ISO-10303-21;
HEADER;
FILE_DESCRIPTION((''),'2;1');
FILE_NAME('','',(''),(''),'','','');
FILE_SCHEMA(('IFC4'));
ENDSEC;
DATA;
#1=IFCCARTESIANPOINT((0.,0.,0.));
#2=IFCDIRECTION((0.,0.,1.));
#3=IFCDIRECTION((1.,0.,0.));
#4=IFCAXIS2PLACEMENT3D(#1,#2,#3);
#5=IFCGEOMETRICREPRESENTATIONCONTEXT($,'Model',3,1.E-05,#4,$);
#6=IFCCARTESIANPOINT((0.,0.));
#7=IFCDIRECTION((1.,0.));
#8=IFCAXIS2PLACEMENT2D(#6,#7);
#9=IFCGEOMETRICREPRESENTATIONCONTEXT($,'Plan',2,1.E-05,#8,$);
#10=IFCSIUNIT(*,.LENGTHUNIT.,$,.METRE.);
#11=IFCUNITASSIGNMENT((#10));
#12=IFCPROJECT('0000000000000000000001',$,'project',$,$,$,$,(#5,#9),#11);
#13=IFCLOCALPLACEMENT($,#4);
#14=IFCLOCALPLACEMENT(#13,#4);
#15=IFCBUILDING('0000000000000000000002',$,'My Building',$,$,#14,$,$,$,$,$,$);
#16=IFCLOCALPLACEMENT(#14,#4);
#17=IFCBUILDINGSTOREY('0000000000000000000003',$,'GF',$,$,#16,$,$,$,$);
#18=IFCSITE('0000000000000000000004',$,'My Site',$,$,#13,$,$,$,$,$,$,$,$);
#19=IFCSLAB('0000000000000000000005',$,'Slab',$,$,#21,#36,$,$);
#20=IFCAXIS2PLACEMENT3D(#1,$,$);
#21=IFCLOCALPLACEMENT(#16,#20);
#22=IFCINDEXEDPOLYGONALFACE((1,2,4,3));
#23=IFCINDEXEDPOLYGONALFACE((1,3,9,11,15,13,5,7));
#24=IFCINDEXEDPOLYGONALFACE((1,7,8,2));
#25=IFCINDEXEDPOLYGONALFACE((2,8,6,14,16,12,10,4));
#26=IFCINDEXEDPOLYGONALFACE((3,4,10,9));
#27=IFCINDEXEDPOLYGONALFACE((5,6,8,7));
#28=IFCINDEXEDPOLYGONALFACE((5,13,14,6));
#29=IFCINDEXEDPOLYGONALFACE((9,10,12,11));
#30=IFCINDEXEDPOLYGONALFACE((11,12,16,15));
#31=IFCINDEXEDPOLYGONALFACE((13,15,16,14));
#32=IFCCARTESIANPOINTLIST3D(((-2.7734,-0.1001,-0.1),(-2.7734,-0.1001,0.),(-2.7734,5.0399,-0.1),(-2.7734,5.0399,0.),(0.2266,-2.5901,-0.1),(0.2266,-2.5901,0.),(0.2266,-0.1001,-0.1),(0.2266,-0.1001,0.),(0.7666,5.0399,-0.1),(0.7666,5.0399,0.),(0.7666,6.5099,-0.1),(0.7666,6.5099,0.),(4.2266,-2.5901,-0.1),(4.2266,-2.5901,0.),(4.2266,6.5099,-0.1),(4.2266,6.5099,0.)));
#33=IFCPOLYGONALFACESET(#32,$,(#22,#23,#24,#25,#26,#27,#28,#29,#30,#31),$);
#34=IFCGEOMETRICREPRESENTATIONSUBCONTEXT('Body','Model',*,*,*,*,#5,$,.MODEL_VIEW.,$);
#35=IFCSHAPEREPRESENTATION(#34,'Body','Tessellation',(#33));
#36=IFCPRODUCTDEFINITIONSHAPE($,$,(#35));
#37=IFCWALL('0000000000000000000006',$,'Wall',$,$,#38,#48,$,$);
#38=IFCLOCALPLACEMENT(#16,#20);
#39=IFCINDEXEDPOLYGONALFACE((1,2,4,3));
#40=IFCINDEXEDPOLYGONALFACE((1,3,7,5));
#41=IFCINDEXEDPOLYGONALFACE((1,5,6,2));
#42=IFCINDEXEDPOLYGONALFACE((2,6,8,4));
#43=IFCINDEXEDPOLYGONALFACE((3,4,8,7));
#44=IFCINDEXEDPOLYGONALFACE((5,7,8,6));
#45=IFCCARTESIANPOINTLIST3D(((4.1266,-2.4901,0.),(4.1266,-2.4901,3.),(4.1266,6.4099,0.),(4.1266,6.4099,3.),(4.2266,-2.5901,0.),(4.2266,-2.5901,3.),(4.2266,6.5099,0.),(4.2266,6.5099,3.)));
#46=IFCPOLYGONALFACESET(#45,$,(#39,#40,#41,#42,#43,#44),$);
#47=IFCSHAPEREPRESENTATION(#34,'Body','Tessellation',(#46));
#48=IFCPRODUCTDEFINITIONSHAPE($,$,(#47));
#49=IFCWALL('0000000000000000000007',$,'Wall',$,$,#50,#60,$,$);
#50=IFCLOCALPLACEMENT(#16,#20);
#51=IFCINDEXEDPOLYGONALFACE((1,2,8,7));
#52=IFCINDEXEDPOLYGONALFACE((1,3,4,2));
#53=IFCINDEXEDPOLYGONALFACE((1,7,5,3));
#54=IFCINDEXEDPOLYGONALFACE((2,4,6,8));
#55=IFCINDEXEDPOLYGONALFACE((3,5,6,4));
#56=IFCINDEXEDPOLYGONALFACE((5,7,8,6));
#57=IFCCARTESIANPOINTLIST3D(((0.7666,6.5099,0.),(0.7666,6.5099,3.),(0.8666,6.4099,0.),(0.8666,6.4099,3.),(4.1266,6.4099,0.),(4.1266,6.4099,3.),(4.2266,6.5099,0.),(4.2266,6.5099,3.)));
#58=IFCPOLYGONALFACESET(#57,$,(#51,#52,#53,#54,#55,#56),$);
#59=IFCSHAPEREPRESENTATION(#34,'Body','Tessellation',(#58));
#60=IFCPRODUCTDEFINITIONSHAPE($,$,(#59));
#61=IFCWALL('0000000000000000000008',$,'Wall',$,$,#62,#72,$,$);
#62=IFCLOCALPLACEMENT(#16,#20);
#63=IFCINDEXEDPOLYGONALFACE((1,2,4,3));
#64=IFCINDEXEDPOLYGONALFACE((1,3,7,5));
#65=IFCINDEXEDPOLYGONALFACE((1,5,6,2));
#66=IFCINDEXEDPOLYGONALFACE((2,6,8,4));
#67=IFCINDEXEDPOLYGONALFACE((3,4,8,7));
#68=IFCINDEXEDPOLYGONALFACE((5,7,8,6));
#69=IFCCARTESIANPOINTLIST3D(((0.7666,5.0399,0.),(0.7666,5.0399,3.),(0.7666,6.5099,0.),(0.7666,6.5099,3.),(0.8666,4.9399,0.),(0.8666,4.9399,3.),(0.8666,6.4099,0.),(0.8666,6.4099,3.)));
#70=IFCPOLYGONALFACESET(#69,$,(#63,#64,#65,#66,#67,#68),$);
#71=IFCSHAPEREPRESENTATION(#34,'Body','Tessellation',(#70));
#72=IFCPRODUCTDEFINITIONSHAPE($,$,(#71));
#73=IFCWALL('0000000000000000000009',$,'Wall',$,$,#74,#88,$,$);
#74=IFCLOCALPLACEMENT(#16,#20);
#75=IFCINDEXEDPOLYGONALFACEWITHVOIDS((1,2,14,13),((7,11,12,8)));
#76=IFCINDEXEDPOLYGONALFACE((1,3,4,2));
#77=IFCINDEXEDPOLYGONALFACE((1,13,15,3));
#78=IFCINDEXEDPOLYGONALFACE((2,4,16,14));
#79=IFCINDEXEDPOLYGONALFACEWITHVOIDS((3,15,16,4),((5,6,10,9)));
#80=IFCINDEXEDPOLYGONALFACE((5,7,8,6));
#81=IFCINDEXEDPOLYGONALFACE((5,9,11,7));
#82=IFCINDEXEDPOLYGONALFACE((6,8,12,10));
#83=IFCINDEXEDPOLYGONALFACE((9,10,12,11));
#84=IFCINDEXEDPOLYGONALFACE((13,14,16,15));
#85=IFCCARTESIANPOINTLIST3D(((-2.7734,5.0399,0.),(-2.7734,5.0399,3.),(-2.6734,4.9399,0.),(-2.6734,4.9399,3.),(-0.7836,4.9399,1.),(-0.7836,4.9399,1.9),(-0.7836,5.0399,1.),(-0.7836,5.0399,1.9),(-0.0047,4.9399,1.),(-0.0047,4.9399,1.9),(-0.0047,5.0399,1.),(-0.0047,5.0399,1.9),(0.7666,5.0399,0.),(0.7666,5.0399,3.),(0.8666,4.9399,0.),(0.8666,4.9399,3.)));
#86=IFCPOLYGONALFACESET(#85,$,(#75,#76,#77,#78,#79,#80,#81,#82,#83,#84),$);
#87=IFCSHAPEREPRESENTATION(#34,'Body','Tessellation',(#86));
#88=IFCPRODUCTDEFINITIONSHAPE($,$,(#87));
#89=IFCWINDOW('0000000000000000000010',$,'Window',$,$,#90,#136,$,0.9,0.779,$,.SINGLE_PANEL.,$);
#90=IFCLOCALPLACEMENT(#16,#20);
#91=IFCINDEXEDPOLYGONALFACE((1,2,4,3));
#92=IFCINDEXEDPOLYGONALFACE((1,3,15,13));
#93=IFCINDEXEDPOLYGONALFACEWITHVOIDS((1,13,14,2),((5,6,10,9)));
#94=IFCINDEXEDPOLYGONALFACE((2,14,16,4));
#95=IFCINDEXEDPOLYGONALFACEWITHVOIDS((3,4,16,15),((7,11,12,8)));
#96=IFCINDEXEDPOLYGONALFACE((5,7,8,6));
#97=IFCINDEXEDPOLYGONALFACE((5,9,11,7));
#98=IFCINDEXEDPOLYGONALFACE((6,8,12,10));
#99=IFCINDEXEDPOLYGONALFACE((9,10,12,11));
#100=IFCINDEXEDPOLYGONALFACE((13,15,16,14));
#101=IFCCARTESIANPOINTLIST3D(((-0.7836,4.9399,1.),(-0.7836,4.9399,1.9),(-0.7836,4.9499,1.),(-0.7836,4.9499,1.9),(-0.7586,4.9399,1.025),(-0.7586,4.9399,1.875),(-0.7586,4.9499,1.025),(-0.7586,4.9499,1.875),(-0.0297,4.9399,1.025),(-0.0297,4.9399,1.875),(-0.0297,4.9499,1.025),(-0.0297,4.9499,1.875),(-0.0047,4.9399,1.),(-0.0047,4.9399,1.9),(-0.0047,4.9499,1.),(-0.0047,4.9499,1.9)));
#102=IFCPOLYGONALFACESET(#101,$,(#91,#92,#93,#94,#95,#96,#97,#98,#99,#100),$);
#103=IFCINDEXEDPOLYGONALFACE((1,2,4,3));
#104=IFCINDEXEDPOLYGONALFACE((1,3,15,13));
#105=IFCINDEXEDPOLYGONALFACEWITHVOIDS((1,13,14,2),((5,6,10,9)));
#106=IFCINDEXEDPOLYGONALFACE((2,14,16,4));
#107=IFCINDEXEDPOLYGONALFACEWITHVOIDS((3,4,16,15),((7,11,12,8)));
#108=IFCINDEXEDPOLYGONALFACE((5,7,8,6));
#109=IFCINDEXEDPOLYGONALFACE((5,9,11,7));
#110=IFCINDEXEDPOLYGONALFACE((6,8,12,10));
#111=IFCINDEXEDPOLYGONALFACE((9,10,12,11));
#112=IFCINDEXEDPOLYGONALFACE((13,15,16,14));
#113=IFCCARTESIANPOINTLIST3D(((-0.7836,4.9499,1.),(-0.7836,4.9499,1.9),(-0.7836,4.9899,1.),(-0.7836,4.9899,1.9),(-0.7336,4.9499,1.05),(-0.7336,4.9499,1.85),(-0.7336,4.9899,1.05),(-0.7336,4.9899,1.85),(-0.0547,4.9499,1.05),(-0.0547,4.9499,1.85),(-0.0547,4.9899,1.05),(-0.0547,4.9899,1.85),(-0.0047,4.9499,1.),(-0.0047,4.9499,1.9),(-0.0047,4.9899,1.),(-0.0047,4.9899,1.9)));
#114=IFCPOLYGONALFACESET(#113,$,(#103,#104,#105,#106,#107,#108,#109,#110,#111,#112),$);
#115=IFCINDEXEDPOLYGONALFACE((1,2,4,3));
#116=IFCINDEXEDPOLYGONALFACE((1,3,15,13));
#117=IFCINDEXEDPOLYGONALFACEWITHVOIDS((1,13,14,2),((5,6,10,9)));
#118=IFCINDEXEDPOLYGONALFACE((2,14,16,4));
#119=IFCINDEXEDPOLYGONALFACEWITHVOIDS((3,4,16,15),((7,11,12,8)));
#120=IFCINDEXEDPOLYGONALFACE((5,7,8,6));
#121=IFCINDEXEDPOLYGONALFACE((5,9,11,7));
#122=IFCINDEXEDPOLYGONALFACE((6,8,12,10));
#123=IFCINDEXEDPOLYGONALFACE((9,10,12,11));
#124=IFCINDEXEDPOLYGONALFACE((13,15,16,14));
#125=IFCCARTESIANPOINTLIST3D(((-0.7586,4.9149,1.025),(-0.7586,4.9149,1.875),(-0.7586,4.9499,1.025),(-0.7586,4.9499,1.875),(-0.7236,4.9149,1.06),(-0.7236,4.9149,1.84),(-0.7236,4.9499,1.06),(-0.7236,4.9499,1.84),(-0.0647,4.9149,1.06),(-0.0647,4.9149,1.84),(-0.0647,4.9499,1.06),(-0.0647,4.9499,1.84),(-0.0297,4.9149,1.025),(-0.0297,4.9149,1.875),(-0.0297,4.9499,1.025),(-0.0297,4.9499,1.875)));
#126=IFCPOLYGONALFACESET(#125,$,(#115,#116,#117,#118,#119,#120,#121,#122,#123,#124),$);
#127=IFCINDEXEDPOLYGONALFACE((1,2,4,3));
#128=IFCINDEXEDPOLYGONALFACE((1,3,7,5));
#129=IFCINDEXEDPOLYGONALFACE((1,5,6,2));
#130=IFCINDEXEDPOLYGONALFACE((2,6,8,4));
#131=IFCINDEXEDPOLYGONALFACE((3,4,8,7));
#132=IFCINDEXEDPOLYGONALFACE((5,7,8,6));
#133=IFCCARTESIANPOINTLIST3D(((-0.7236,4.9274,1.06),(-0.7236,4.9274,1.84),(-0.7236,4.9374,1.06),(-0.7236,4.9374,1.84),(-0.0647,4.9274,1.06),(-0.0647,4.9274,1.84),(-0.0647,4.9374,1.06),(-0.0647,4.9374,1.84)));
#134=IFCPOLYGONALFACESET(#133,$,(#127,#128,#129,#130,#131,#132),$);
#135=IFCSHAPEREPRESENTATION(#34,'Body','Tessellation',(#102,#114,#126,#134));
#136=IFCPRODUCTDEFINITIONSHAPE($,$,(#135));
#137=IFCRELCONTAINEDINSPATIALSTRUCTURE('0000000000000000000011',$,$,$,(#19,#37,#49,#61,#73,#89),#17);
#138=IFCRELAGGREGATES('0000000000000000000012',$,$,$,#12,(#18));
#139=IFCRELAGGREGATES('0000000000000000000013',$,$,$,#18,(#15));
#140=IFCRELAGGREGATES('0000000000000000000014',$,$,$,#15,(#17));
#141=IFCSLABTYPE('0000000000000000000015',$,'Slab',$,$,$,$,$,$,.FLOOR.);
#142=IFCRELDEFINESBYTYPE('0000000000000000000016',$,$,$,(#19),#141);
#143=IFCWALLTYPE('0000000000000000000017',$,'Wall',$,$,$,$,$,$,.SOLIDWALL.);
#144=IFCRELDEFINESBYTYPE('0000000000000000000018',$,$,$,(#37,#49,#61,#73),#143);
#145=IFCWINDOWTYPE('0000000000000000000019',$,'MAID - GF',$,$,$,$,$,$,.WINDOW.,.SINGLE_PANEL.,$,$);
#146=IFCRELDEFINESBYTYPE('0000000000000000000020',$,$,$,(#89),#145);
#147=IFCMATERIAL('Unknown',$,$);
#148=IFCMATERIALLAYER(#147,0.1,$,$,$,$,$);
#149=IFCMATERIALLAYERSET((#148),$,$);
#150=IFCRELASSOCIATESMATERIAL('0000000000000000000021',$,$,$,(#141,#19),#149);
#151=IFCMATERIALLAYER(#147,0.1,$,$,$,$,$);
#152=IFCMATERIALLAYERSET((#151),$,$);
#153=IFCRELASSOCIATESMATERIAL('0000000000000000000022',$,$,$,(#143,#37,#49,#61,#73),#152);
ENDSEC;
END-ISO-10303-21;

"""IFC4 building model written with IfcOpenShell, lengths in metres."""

from ifc_helpers import new_model, entity, si_unit, frame, origin_with_axes, origin_2d_with_axis, place, context, subcontext, project, spatial, line, indexed_curve, outline, extrude, shape, source, transform, mapped, material, layer, layer_set, layer_usage, type_object, type_shapes, element, fill, save


model = new_model("IFC4")

# Units and contexts
model_context = context("Model", 3, precision=1e-05, world=origin_with_axes())
plan_context = context("Plan", 2, precision=1e-05, world=origin_2d_with_axis())
body_context_1 = subcontext(model_context, "Body", "Model", "MODEL_VIEW")
body_context_2 = subcontext(plan_context, "Body", "Plan", "PLAN_VIEW")
ifc_project = project(units=[si_unit("LENGTHUNIT", "METRE")], contexts=[model_context, plan_context])

# Site, building, storey
site_placement = place(None, origin_with_axes())
site = spatial("IfcSite", under=ifc_project, at=site_placement, Name="My Site")
building_placement = place(site_placement, origin_with_axes())
building = spatial("IfcBuilding", under=site, at=building_placement, Name="My Building")
storey_placement = place(building_placement, origin_with_axes())
storey = spatial("IfcBuildingStorey", under=building, at=storey_placement, Name="GF")

# Slab
ifc_material = material(Name="Unknown")
ifc_layer_1 = layer(ifc_material, 0.1)
ifc_layer_set_1 = layer_set([ifc_layer_1])
ifc_layer_usage_1 = layer_usage(ifc_layer_set_1, "AXIS3", "POSITIVE", -0.1)
slab_type = type_object("IfcSlabType", Name="Slab", PredefinedType="FLOOR", material=ifc_layer_set_1)
slab_placement = place(storey_placement, frame((4.2266, -2.5901, 0.0), z_axis=(0.0, 0.0, 1.0), x_axis=(1.0, 0.0, 0.0)))
element("IfcSlab", 1, at=slab_placement, inside=storey, type_object=slab_type, material=ifc_layer_usage_1, Name="Slab", context=body_context_1, shape_type="SweptSolid", body=[
    extrude(outline(indexed_curve([(0.0, 0.0), (0.0, 9.1), (-3.46, 9.1), (-3.46, 7.63), (-7.0, 7.63), (-7.0, 2.49), (-4.0, 2.49), (-4.0, 0.0), (0.0, 0.0)])), frame((0.0, 0.0, -0.1), z_axis=(0.0, 0.0, 1.0), x_axis=(1.0, 0.0, 0.0)), (0.0, 0.0, 1.0), 0.1),
])

# Shared definitions
ifc_layer_2 = layer(ifc_material, 0.1)
ifc_layer_set_2 = layer_set([ifc_layer_2])
wall_type = type_object("IfcWallType", Name="Wall", PredefinedType="SOLIDWALL", material=ifc_layer_set_2)

# Walls
ifc_layer_usage_2 = layer_usage(ifc_layer_set_2, "AXIS2", "POSITIVE", 0.0)
wall_1_placement = place(storey_placement, frame((4.2266, -2.5901, 0.0), z_axis=(0.0, 0.0, 1.0), x_axis=(0.0, 1.0, 0.0)))
element("IfcWall", 2, at=wall_1_placement, inside=storey, type_object=wall_type, material=ifc_layer_usage_2, Name="Wall", context=body_context_1, shape_type="SweptSolid", body=[
    extrude(outline(indexed_curve([(0.0, 0.0), (0.1, 0.1), (9.0, 0.1), (9.1, 0.0)], segments=[line(1, 2, 3, 4, 1)])), origin_with_axes(), (0.0, 0.0, 1.0), 3.0),
])
ifc_layer_usage_3 = layer_usage(ifc_layer_set_2, "AXIS2", "POSITIVE", 0.0)
wall_2_placement = place(storey_placement, frame((4.2266, 6.5099, 0.0), z_axis=(0.0, 0.0, 1.0), x_axis=(-1.0, 0.0, 0.0)))
element("IfcWall", 3, at=wall_2_placement, inside=storey, type_object=wall_type, material=ifc_layer_usage_3, Name="Wall", context=body_context_1, shape_type="SweptSolid", body=[
    extrude(outline(indexed_curve([(0.0, 0.0), (0.1, 0.1), (3.36, 0.1), (3.46, 0.0)], segments=[line(1, 2, 3, 4, 1)])), origin_with_axes(), (0.0, 0.0, 1.0), 3.0),
])
ifc_layer_usage_4 = layer_usage(ifc_layer_set_2, "AXIS2", "POSITIVE", 0.0)
wall_3_placement = place(storey_placement, frame((0.7666, 6.5099, 0.0), z_axis=(0.0, 0.0, 1.0), x_axis=(0.0, -1.0, 0.0)))
element("IfcWall", 4, at=wall_3_placement, inside=storey, type_object=wall_type, material=ifc_layer_usage_4, Name="Wall", context=body_context_1, shape_type="SweptSolid", body=[
    extrude(outline(indexed_curve([(0.0, 0.0), (0.1, 0.1), (1.57, 0.1), (1.47, 0.0)], segments=[line(1, 2, 3, 4, 1)])), origin_with_axes(), (0.0, 0.0, 1.0), 3.0),
])

# Wall, opening, window
ifc_layer_usage_5 = layer_usage(ifc_layer_set_2, "AXIS2", "POSITIVE", 0.0)
wall_4_placement = place(storey_placement, frame((0.7666, 5.0399, 0.0), z_axis=(0.0, 0.0, 1.0), x_axis=(-1.0, 0.0, 0.0)))
wall_4 = element("IfcWall", 5, at=wall_4_placement, inside=storey, type_object=wall_type, material=ifc_layer_usage_5, Name="Wall", context=body_context_1, shape_type="SweptSolid", body=[
    extrude(outline(indexed_curve([(0.0, 0.0), (-0.1, 0.1), (3.44, 0.1), (3.54, 0.0)], segments=[line(1, 2, 3, 4, 1)])), origin_with_axes(), (0.0, 0.0, 1.0), 3.0),
])
shared_shape_1 = source(origin_with_axes(), body_context_1, "Body", "SweptSolid", [
    extrude(outline(indexed_curve([(0.0, 0.0), (0.779, 0.0), (0.779, 0.9), (0.0, 0.9)], segments=[line(1, 2, 3, 4, 1)])), frame((0.0, -0.6, 0.0), z_axis=(0.0, -1.0, 0.0), x_axis=(1.0, 0.0, 0.0)), (0.0, 0.0, -1.0), 1.2),
])
opening_1_placement = place(wall_4_placement, frame((0.7713, 0.0, 1.0), z_axis=(0.0, 0.0, 1.0), x_axis=(1.0, 0.0, 0.0)))
opening_1 = element("IfcOpeningElement", 6, at=opening_1_placement, cuts=wall_4, PredefinedType="OPENING", context=body_context_1, shape_type="MappedRepresentation", body=[
    mapped(shared_shape_1, transform((0.0, 0.0, 0.0), x_axis=(1.0, 0.0, 0.0), y_axis=(0.0, 1.0, 0.0), z_axis=(0.0, 0.0, 1.0), scale=1.0)),
])
window_type_1 = type_object("IfcWindowType", Name="MAID - GF", PartitioningType="SINGLE_PANEL", PredefinedType="WINDOW")
shared_shape_2 = source(origin_with_axes(), body_context_1, "Body", "SweptSolid", [
    extrude(outline(indexed_curve([(0.0, 0.0), (0.779, 0.0), (0.779, 0.9), (0.0, 0.9)], segments=[line(1, 2, 3, 4, 1)]), holes=[indexed_curve([(0.025, 0.025), (0.754, 0.025), (0.754, 0.875), (0.025, 0.875)], segments=[line(1, 2, 3, 4, 1)])]), frame((0.0, 0.09, 0.0), z_axis=(0.0, -1.0, 0.0), x_axis=(1.0, 0.0, 0.0)), (0.0, 0.0, -1.0), 0.01),
    extrude(outline(indexed_curve([(0.0, 0.0), (0.779, 0.0), (0.779, 0.9), (0.0, 0.9)], segments=[line(1, 2, 3, 4, 1)]), holes=[indexed_curve([(0.05, 0.05), (0.729, 0.05), (0.729, 0.85), (0.05, 0.85)], segments=[line(1, 2, 3, 4, 1)])]), frame((0.0, 0.05, 0.0), z_axis=(0.0, -1.0, 0.0), x_axis=(1.0, 0.0, 0.0)), (0.0, 0.0, -1.0), 0.04),
    extrude(outline(indexed_curve([(0.0, 0.0), (0.729, 0.0), (0.729, 0.85), (0.0, 0.85)], segments=[line(1, 2, 3, 4, 1)]), holes=[indexed_curve([(0.035, 0.035), (0.694, 0.035), (0.694, 0.815), (0.035, 0.815)], segments=[line(1, 2, 3, 4, 1)])]), frame((0.025, 0.09, 0.025), z_axis=(0.0, -1.0, 0.0), x_axis=(1.0, 0.0, 0.0)), (0.0, 0.0, -1.0), 0.035),
    extrude(outline(indexed_curve([(0.035, 0.035), (0.694, 0.035), (0.694, 0.815), (0.035, 0.815)], segments=[line(1, 2, 3, 4, 1)])), frame((0.025, 0.1025, 0.025), z_axis=(0.0, -1.0, 0.0), x_axis=(1.0, 0.0, 0.0)), (0.0, 0.0, -1.0), 0.01),
])
shared_shape_3 = source(origin_with_axes(), body_context_2, "Body", "Curve2D", [
    entity("IfcIndexedPolyCurve", entity("IfcCartesianPointList2D", [[0.05, 0.05], [0.729, 0.05]])),
    entity("IfcIndexedPolyCurve", entity("IfcCartesianPointList2D", [[0.0, 0.1], [0.025, 0.1], [0.025, 0.09], [0.05, 0.09], [0.05, 0.05], [0.0, 0.05]]), [entity("IfcLineIndex", [1, 2, 3, 4, 5, 6, 1])]),
    entity("IfcIndexedPolyCurve", entity("IfcCartesianPointList2D", [[0.779, 0.1], [0.754, 0.1], [0.754, 0.09], [0.729, 0.09], [0.729, 0.05], [0.779, 0.05]]), [entity("IfcLineIndex", [1, 2, 3, 4, 5, 6, 1])]),
    entity("IfcIndexedPolyCurve", entity("IfcCartesianPointList2D", [[0.025, 0.09], [0.06, 0.09], [0.06, 0.125], [0.025, 0.125]]), [entity("IfcLineIndex", [1, 2, 3, 4, 1])]),
    entity("IfcIndexedPolyCurve", entity("IfcCartesianPointList2D", [[0.754, 0.09], [0.719, 0.09], [0.719, 0.125], [0.754, 0.125]]), [entity("IfcLineIndex", [1, 2, 3, 4, 1])]),
    entity("IfcIndexedPolyCurve", entity("IfcCartesianPointList2D", [[0.06, 0.09], [0.719, 0.09]])),
    entity("IfcIndexedPolyCurve", entity("IfcCartesianPointList2D", [[0.06, 0.125], [0.719, 0.125]])),
    entity("IfcIndexedPolyCurve", entity("IfcCartesianPointList2D", [[0.06, 0.1075], [0.719, 0.1075]])),
])
type_shapes(window_type_1, [shared_shape_2, shared_shape_3])
window_1_placement = place(opening_1_placement, frame((0.0, 0.0, 0.0), z_axis=(0.0, 0.0, 1.0), x_axis=(1.0, 0.0, 0.0)))
window_1 = element("IfcWindow", 7, at=window_1_placement, inside=storey, type_object=window_type_1, Name="Window", OverallHeight=0.9, OverallWidth=0.779, PartitioningType="SINGLE_PANEL", shapes=[
    shape(body_context_1, "Body", "MappedRepresentation", [mapped(shared_shape_2, transform((0.0, 0.0, 0.0), x_axis=(1.0, 0.0, 0.0), y_axis=(0.0, 1.0, 0.0), z_axis=(0.0, 0.0, 1.0), scale=1.0))]),
    shape(body_context_2, "Body", "MappedRepresentation", [mapped(shared_shape_3, transform((0.0, 0.0, 0.0), x_axis=(1.0, 0.0, 0.0), y_axis=(0.0, 1.0, 0.0), z_axis=(0.0, 0.0, 1.0), scale=1.0))]),
])
fill(opening_1, window_1)

save(model, "model.ifc")
